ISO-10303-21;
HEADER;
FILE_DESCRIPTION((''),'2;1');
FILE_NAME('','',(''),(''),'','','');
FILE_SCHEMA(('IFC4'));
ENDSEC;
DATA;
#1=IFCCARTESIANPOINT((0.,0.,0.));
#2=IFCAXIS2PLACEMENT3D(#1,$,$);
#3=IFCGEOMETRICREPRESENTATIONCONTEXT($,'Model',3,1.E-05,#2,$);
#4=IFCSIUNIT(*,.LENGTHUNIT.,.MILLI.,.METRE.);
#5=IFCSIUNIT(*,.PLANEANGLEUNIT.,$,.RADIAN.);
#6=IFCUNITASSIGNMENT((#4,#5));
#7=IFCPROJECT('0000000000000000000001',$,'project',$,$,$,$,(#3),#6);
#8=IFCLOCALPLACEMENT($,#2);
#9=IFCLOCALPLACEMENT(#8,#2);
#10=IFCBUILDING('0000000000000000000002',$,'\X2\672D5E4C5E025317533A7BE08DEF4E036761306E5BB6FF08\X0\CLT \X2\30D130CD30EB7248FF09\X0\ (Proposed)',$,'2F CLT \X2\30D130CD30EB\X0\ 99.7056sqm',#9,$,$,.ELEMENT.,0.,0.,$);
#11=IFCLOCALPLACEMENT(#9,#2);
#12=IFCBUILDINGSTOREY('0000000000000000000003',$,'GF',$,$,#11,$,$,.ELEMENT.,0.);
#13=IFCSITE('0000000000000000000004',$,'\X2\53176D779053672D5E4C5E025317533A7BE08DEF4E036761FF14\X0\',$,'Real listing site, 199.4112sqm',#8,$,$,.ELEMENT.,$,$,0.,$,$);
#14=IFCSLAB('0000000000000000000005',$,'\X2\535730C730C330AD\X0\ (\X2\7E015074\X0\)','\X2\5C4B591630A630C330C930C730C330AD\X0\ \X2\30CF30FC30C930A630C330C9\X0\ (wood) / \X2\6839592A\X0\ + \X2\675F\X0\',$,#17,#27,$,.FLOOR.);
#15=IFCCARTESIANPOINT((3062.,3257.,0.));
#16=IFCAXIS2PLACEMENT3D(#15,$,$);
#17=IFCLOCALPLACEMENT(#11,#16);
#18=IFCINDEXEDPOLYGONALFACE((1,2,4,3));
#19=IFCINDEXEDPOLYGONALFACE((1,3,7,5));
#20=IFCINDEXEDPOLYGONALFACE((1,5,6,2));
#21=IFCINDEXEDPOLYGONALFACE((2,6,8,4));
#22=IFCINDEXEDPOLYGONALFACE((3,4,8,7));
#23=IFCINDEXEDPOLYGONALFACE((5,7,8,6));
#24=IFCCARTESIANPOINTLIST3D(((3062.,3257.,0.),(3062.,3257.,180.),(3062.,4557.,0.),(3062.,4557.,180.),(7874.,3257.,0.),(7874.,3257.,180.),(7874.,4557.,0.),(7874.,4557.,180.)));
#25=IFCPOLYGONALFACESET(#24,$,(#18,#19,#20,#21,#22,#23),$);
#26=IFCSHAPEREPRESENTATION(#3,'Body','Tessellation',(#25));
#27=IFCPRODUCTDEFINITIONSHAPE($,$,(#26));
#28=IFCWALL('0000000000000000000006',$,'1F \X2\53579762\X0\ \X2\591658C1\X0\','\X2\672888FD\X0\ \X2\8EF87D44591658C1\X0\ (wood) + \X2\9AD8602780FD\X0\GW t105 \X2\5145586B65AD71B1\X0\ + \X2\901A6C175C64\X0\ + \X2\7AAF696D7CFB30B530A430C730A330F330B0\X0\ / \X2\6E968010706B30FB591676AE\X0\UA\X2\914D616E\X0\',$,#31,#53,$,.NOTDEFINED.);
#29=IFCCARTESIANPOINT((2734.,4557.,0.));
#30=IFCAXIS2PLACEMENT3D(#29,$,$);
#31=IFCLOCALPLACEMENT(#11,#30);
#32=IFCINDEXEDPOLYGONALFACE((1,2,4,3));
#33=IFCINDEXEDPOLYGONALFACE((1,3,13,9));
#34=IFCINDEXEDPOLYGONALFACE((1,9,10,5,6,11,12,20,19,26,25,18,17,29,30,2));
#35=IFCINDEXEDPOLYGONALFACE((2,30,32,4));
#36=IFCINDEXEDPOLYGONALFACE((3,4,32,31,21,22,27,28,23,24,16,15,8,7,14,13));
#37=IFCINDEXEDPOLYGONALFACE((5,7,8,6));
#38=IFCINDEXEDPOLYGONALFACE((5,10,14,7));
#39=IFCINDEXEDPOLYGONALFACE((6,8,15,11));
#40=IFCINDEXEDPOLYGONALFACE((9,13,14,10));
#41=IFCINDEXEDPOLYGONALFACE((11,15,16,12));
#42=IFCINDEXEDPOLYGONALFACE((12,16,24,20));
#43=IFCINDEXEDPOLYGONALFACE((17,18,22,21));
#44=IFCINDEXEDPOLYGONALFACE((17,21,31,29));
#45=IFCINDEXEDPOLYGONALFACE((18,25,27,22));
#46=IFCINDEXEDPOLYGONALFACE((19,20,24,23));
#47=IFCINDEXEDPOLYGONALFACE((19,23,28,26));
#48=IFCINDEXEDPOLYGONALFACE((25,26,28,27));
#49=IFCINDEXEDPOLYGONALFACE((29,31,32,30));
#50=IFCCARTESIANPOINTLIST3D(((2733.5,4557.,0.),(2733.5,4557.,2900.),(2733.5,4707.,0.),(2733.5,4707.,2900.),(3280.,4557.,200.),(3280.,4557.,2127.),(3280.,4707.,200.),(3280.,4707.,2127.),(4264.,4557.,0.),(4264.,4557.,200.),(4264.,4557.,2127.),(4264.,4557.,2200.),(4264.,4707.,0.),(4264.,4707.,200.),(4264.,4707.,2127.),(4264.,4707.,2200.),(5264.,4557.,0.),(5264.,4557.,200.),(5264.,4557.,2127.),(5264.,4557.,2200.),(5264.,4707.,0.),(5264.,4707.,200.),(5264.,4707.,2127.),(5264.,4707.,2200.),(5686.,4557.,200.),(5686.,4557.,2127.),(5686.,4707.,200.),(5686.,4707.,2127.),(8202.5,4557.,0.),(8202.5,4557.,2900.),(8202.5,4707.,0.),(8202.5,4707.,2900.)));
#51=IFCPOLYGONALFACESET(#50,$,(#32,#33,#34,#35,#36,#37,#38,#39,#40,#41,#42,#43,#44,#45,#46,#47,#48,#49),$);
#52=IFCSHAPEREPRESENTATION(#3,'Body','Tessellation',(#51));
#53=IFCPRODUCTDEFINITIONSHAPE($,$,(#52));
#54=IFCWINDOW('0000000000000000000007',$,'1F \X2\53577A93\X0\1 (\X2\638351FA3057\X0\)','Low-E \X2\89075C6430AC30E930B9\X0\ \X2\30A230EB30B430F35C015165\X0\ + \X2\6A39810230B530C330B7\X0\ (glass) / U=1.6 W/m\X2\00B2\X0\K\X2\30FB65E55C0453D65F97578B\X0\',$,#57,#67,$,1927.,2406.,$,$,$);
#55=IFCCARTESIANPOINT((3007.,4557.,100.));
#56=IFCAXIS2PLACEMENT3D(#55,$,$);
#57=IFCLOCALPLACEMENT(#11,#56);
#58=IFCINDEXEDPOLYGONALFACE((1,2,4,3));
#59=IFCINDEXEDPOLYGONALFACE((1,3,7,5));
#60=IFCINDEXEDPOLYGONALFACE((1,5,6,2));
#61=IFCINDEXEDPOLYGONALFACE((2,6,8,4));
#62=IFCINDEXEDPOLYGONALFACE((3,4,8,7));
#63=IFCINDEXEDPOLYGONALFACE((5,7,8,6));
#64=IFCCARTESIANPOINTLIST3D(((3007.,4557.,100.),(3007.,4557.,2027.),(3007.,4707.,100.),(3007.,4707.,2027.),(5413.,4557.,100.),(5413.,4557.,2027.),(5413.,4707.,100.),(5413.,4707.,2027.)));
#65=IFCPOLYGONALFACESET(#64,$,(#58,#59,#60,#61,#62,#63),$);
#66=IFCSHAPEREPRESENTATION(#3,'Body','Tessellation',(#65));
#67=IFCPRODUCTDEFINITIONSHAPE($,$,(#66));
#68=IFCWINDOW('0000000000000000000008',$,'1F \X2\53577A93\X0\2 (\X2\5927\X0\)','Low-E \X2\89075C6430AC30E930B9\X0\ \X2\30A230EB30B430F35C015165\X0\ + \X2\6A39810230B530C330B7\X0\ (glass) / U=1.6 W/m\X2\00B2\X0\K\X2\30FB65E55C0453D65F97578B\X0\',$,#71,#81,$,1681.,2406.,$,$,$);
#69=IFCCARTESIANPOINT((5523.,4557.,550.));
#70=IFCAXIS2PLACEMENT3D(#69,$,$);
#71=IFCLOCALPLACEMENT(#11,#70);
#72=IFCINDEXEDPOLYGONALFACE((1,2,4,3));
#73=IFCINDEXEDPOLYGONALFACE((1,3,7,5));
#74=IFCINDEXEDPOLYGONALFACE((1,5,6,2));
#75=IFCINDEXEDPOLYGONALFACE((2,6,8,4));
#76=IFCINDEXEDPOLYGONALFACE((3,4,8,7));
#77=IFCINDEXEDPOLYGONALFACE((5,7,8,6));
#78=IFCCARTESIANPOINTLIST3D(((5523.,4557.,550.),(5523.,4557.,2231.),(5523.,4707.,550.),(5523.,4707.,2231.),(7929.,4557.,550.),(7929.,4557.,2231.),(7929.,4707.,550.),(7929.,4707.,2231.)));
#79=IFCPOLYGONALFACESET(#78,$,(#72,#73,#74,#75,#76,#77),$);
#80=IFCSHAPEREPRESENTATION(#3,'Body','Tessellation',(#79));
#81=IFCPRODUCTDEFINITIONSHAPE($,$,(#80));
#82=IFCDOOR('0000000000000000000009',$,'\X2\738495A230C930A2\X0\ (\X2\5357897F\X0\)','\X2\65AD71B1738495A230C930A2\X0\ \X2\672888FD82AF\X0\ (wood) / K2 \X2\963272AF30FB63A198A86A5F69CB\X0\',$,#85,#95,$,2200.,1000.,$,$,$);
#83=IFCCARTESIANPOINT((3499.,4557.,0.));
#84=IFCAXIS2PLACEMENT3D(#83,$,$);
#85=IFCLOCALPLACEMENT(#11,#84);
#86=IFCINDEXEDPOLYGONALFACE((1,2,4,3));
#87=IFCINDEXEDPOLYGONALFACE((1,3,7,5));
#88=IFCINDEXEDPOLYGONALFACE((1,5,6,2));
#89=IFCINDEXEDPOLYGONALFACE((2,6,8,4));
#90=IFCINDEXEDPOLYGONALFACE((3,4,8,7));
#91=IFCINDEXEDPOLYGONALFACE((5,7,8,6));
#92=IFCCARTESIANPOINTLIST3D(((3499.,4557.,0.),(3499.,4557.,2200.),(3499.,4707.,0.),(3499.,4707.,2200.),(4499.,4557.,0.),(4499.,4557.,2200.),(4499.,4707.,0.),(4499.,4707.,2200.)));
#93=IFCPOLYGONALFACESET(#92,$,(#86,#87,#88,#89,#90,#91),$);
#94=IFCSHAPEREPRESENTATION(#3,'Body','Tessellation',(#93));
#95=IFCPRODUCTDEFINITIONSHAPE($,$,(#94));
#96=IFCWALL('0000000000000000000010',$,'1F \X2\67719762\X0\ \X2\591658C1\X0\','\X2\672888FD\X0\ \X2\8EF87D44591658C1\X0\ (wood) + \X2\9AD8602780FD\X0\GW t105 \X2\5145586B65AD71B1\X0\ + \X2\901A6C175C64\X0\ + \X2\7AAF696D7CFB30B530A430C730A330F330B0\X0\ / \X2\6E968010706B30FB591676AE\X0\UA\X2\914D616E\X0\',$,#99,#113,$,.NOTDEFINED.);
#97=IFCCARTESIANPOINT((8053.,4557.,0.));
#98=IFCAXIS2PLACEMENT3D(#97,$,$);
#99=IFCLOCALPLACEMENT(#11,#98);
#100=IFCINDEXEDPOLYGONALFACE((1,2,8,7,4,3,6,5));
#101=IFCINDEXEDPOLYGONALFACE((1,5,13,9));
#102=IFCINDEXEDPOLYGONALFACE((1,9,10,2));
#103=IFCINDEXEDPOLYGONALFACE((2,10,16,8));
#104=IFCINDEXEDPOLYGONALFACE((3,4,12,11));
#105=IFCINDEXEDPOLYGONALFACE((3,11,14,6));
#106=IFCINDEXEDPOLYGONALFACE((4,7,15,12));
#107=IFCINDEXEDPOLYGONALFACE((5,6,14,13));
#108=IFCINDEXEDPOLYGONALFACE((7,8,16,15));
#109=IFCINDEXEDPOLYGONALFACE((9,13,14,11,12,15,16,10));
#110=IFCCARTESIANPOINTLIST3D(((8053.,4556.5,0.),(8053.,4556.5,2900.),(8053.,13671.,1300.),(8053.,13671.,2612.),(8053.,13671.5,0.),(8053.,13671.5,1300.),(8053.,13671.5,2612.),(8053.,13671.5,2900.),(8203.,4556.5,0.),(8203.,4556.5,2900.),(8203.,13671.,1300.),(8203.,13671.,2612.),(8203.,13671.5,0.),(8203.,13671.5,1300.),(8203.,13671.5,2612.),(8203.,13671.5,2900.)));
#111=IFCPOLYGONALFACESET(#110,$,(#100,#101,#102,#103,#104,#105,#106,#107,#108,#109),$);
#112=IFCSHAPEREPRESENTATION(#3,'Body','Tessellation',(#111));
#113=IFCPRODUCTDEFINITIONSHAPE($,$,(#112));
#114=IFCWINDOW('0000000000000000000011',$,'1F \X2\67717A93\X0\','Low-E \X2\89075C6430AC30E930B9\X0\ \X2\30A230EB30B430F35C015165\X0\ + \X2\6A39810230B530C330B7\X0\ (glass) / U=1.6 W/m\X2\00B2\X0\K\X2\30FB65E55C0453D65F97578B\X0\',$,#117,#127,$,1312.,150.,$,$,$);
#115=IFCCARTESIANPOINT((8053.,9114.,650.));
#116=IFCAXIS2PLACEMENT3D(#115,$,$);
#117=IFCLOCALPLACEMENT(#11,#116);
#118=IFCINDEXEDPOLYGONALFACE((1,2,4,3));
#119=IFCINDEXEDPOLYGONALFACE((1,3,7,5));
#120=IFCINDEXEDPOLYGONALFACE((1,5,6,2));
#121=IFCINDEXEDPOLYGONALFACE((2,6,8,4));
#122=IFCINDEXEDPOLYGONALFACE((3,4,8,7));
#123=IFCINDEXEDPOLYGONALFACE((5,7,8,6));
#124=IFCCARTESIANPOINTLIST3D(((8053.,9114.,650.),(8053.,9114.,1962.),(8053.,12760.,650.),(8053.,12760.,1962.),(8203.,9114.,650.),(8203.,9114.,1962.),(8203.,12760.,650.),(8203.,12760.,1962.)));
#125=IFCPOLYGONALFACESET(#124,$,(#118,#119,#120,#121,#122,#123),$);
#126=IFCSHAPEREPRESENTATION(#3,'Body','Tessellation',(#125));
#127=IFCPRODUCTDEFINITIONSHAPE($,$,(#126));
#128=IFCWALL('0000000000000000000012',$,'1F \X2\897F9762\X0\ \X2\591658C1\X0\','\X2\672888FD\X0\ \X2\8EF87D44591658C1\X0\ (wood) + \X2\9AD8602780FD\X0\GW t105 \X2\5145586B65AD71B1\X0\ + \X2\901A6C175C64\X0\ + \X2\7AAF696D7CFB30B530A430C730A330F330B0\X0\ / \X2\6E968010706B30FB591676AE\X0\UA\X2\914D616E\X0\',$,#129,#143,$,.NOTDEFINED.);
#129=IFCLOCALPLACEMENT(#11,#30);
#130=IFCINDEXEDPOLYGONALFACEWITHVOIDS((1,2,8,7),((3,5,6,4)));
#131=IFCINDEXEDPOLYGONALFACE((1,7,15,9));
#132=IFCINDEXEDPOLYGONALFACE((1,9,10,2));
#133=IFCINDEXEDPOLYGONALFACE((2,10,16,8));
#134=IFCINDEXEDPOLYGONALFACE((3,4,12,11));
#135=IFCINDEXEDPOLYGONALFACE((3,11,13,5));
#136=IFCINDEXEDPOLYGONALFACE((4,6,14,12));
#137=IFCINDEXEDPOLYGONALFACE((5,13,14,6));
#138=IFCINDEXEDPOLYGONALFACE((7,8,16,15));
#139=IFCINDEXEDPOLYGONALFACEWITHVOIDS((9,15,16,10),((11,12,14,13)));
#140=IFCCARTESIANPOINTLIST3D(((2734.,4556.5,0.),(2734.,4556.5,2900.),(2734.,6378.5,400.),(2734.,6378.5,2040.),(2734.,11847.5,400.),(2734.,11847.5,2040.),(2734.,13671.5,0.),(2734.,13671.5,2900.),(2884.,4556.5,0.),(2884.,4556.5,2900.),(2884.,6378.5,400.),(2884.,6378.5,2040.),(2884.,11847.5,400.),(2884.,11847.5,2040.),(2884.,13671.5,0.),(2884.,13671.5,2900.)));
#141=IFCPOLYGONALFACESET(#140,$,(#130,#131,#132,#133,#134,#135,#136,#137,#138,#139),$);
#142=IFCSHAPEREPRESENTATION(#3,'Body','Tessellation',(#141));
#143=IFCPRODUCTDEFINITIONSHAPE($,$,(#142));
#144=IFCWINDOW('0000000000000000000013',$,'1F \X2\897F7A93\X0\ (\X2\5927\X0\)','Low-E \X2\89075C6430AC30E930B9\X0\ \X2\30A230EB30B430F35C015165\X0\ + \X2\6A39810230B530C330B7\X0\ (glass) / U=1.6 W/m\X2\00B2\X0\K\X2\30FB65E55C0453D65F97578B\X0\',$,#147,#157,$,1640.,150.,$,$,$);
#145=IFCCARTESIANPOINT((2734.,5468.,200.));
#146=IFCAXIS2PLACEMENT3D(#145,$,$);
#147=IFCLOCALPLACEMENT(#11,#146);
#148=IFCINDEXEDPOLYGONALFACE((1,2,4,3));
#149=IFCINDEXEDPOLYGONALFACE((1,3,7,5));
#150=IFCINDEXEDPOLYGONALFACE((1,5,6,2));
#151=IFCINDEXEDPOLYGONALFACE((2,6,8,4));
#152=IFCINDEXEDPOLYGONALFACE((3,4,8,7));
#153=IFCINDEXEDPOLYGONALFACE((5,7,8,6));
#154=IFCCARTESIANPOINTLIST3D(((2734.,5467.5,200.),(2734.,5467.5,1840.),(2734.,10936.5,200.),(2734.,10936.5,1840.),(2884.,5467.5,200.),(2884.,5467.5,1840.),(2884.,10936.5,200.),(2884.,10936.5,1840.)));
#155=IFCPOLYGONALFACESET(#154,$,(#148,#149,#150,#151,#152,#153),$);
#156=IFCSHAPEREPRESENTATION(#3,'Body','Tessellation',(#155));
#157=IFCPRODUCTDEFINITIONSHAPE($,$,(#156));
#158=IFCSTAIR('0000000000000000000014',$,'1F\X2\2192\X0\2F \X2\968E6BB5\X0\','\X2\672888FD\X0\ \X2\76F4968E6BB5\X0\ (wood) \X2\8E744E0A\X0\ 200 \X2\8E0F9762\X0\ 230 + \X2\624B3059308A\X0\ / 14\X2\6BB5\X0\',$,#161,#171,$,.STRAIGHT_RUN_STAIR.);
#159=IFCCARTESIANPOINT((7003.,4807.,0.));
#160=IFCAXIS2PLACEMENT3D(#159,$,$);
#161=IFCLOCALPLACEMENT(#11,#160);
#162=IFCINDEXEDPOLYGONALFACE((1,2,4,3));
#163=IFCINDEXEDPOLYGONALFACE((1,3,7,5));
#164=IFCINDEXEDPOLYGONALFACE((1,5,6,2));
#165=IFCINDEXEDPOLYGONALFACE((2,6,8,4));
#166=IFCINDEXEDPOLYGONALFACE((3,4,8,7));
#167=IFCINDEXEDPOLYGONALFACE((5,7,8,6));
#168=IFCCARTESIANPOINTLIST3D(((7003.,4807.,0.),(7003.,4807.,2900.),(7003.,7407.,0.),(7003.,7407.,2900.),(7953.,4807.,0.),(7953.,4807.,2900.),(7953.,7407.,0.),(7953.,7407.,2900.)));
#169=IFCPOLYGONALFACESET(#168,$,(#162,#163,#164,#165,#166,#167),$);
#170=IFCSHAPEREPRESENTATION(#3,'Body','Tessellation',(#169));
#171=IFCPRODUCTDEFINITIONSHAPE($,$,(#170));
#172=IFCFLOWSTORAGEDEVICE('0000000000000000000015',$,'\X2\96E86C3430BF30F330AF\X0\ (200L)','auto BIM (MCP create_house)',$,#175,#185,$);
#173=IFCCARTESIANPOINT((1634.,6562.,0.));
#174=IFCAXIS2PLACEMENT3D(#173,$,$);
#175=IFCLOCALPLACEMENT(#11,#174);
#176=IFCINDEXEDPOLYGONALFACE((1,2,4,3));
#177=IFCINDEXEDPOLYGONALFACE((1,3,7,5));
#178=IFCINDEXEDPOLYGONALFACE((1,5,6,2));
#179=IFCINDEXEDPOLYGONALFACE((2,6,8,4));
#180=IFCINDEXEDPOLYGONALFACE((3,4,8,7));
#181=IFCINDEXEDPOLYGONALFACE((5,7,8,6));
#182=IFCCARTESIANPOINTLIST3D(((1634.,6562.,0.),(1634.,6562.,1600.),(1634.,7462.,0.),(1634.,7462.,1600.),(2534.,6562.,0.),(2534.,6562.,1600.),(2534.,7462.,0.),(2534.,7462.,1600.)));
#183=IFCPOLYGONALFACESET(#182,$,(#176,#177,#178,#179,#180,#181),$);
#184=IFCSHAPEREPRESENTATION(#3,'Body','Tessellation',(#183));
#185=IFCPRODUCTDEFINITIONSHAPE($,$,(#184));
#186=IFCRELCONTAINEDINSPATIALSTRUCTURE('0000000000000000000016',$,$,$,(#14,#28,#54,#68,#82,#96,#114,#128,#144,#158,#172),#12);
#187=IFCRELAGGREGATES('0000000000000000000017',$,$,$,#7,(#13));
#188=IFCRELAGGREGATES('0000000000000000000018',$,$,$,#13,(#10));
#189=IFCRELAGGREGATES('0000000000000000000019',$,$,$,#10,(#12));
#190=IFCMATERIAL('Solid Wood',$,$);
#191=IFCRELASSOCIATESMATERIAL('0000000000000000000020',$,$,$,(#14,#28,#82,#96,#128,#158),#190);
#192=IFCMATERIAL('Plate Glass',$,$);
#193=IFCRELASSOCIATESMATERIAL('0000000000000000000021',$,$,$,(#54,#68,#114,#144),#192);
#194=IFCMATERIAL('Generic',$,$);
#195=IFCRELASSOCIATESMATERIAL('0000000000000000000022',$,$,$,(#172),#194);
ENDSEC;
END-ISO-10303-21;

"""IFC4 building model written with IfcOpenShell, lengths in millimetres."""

from ifc_helpers import new_model, si_unit, frame, frame_2d, origin, place, context, project, spatial, rectangle, extrude, material, element, fill, save


model = new_model("IFC4")

# Units and contexts
model_context = context("Model", 3, precision=1e-05, world=origin())
ifc_project = project(units=[si_unit("LENGTHUNIT", "METRE", prefix="MILLI"), si_unit("PLANEANGLEUNIT", "RADIAN")], contexts=[model_context])

# Site, building, storey
site_placement = place(None, origin())
site = spatial("IfcSite", under=ifc_project, at=site_placement, Name="北海道札幌市北区篠路七条４", ObjectType="Real listing site, 199.4112sqm", CompositionType="ELEMENT", RefElevation=0.0)
building_placement = place(site_placement, origin())
building = spatial("IfcBuilding", under=site, at=building_placement, Name="札幌市北区篠路七条の家（CLT パネル版） (Proposed)", ObjectType="2F CLT パネル 99.7056sqm", CompositionType="ELEMENT", ElevationOfRefHeight=0.0, ElevationOfTerrain=0.0)
storey_placement = place(building_placement, origin())
storey = spatial("IfcBuildingStorey", under=building, at=storey_placement, Name="GF", CompositionType="ELEMENT", Elevation=0.0)

# Slab
ifc_material_1 = material(Name="Solid Wood")
slab_1_placement = place(storey_placement, frame((3062.0, 3257.0, 0.0)))
element("IfcSlab", 1, at=slab_1_placement, inside=storey, material=ifc_material_1, Name="南デッキ (縁側)", Description="屋外ウッドデッキ ハードウッド (wood) / 根太 + 束", PredefinedType="FLOOR", context=model_context, shape_type="SweptSolid", body=[
    extrude(rectangle(XDim=4812.0, YDim=1300.0, at=frame_2d((2406.0, 650.0))), frame((3062.0, 3257.0, 0.0)), (0.0, 0.0, 1.0), 180.0),
])

# Wall, openings, windows, door
wall_1_placement = place(storey_placement, frame((2734.0, 4557.0, 0.0)))
wall_1 = element("IfcWall", 2, at=wall_1_placement, inside=storey, material=ifc_material_1, Name="1F 南面 外壁", Description="木製 軸組外壁 (wood) + 高性能GW t105 充填断熱 + 通気層 + 窯業系サイディング / 準耐火・外皮UA配慮", PredefinedType="NOTDEFINED", context=model_context, shape_type="SweptSolid", body=[
    extrude(rectangle(XDim=5469.0, YDim=150.0, at=frame_2d((2734.0, 75.0))), frame((2734.0, 4557.0, 0.0)), (0.0, 0.0, 1.0), 2900.0),
])
opening_1_placement = place(storey_placement, frame((3007.0, 4557.0, 100.0)))
opening_1 = element("IfcOpeningElement", 3, at=opening_1_placement, cuts=wall_1, PredefinedType="NOTDEFINED", context=model_context, shape_type="SweptSolid", body=[
    extrude(rectangle(XDim=2406.0, YDim=150.0, at=frame_2d((1203.0, 75.0))), frame((3007.0, 4557.0, 100.0)), (0.0, 0.0, 1.0), 1927.0),
])
opening_2_placement = place(storey_placement, frame((5523.0, 4557.0, 550.0)))
opening_2 = element("IfcOpeningElement", 4, at=opening_2_placement, cuts=wall_1, PredefinedType="NOTDEFINED", context=model_context, shape_type="SweptSolid", body=[
    extrude(rectangle(XDim=2406.0, YDim=150.0, at=frame_2d((1203.0, 75.0))), frame((5523.0, 4557.0, 550.0)), (0.0, 0.0, 1.0), 1681.0),
])
opening_3_placement = place(storey_placement, frame((3499.0, 4557.0, 0.0)))
opening_3 = element("IfcOpeningElement", 5, at=opening_3_placement, cuts=wall_1, PredefinedType="NOTDEFINED", context=model_context, shape_type="SweptSolid", body=[
    extrude(rectangle(XDim=1000.0, YDim=150.0, at=frame_2d((500.0, 75.0))), frame((3499.0, 4557.0, 0.0)), (0.0, 0.0, 1.0), 2200.0),
])
ifc_material_2 = material(Name="Plate Glass")
window_1_placement = place(storey_placement, frame((3007.0, 4557.0, 100.0)))
window_1 = element("IfcWindow", 6, at=window_1_placement, inside=storey, material=ifc_material_2, Name="1F 南窓1 (掃出し)", Description="Low-E 複層ガラス アルゴン封入 + 樹脂サッシ (glass) / U=1.6 W/m²K・日射取得型", OverallHeight=1927.0, OverallWidth=2406.0, context=model_context, shape_type="SweptSolid", body=[
    extrude(rectangle(XDim=2406.0, YDim=150.0, at=frame_2d((1203.0, 75.0))), frame((3007.0, 4557.0, 100.0)), (0.0, 0.0, 1.0), 1927.0),
])
fill(opening_1, window_1)
window_2_placement = place(storey_placement, frame((5523.0, 4557.0, 550.0)))
window_2 = element("IfcWindow", 7, at=window_2_placement, inside=storey, material=ifc_material_2, Name="1F 南窓2 (大)", Description="Low-E 複層ガラス アルゴン封入 + 樹脂サッシ (glass) / U=1.6 W/m²K・日射取得型", OverallHeight=1681.0, OverallWidth=2406.0, context=model_context, shape_type="SweptSolid", body=[
    extrude(rectangle(XDim=2406.0, YDim=150.0, at=frame_2d((1203.0, 75.0))), frame((5523.0, 4557.0, 550.0)), (0.0, 0.0, 1.0), 1681.0),
])
fill(opening_2, window_2)
door_placement = place(storey_placement, frame((3499.0, 4557.0, 0.0)))
door = element("IfcDoor", 8, at=door_placement, inside=storey, material=ifc_material_1, Name="玄関ドア (南西)", Description="断熱玄関ドア 木製芯 (wood) / K2 防犯・採風機構", OverallHeight=2200.0, OverallWidth=1000.0, context=model_context, shape_type="SweptSolid", body=[
    extrude(rectangle(XDim=1000.0, YDim=150.0, at=frame_2d((500.0, 75.0))), frame((3499.0, 4557.0, 0.0)), (0.0, 0.0, 1.0), 2200.0),
])
fill(opening_3, door)

# Walls, openings, windows
wall_2_placement = place(storey_placement, frame((8053.0, 4557.0, 0.0)))
wall_2 = element("IfcWall", 9, at=wall_2_placement, inside=storey, material=ifc_material_1, Name="1F 東面 外壁", Description="木製 軸組外壁 (wood) + 高性能GW t105 充填断熱 + 通気層 + 窯業系サイディング / 準耐火・外皮UA配慮", PredefinedType="NOTDEFINED", context=model_context, shape_type="SweptSolid", body=[
    extrude(rectangle(XDim=150.0, YDim=9115.0, at=frame_2d((75.0, 4557.0))), frame((8053.0, 4557.0, 0.0)), (0.0, 0.0, 1.0), 2900.0),
])
opening_4_placement = place(storey_placement, frame((8053.0, 9114.0, 650.0)))
opening_4 = element("IfcOpeningElement", 10, at=opening_4_placement, cuts=wall_2, PredefinedType="NOTDEFINED", context=model_context, shape_type="SweptSolid", body=[
    extrude(rectangle(XDim=150.0, YDim=3646.0, at=frame_2d((75.0, 1823.0))), frame((8053.0, 9114.0, 650.0)), (0.0, 0.0, 1.0), 1312.0),
])
window_3_placement = place(storey_placement, frame((8053.0, 9114.0, 650.0)))
window_3 = element("IfcWindow", 11, at=window_3_placement, inside=storey, material=ifc_material_2, Name="1F 東窓", Description="Low-E 複層ガラス アルゴン封入 + 樹脂サッシ (glass) / U=1.6 W/m²K・日射取得型", OverallHeight=1312.0, OverallWidth=150.0, context=model_context, shape_type="SweptSolid", body=[
    extrude(rectangle(XDim=150.0, YDim=3646.0, at=frame_2d((75.0, 1823.0))), frame((8053.0, 9114.0, 650.0)), (0.0, 0.0, 1.0), 1312.0),
])
fill(opening_4, window_3)
wall_3_placement = place(storey_placement, frame((2734.0, 4557.0, 0.0)))
wall_3 = element("IfcWall", 12, at=wall_3_placement, inside=storey, material=ifc_material_1, Name="1F 西面 外壁", Description="木製 軸組外壁 (wood) + 高性能GW t105 充填断熱 + 通気層 + 窯業系サイディング / 準耐火・外皮UA配慮", PredefinedType="NOTDEFINED", context=model_context, shape_type="SweptSolid", body=[
    extrude(rectangle(XDim=150.0, YDim=9115.0, at=frame_2d((75.0, 4557.0))), frame((2734.0, 4557.0, 0.0)), (0.0, 0.0, 1.0), 2900.0),
])
opening_5_placement = place(storey_placement, frame((2734.0, 5468.0, 200.0)))
opening_5 = element("IfcOpeningElement", 13, at=opening_5_placement, cuts=wall_3, PredefinedType="NOTDEFINED", context=model_context, shape_type="SweptSolid", body=[
    extrude(rectangle(XDim=150.0, YDim=5469.0, at=frame_2d((75.0, 2734.0))), frame((2734.0, 5468.0, 200.0)), (0.0, 0.0, 1.0), 1640.0),
])
window_4_placement = place(storey_placement, frame((2734.0, 5468.0, 200.0)))
window_4 = element("IfcWindow", 14, at=window_4_placement, inside=storey, material=ifc_material_2, Name="1F 西窓 (大)", Description="Low-E 複層ガラス アルゴン封入 + 樹脂サッシ (glass) / U=1.6 W/m²K・日射取得型", OverallHeight=1640.0, OverallWidth=150.0, context=model_context, shape_type="SweptSolid", body=[
    extrude(rectangle(XDim=150.0, YDim=5469.0, at=frame_2d((75.0, 2734.0))), frame((2734.0, 5468.0, 200.0)), (0.0, 0.0, 1.0), 1640.0),
])
fill(opening_5, window_4)

# Stair
stair_placement = place(storey_placement, frame((7003.0, 4807.0, 0.0)))
element("IfcStair", 15, at=stair_placement, inside=storey, material=ifc_material_1, Name="1F→2F 階段", Description="木製 直階段 (wood) 蹴上 200 踏面 230 + 手すり / 14段", PredefinedType="STRAIGHT_RUN_STAIR", context=model_context, shape_type="SweptSolid", body=[
    extrude(rectangle(XDim=950.0, YDim=2600.0, at=frame_2d((475.0, 1300.0))), frame((7003.0, 4807.0, 0.0)), (0.0, 0.0, 1.0), 2900.0),
])

# Shared definitions
ifc_material_3 = material(Name="Generic")

# Flow storage device
flow_storage_device_placement = place(storey_placement, frame((1634.0, 6562.0, 0.0)))
element("IfcFlowStorageDevice", 16, at=flow_storage_device_placement, inside=storey, material=ifc_material_3, Name="雨水タンク (200L)", Description="auto BIM (MCP create_house)", context=model_context, shape_type="SweptSolid", body=[
    extrude(rectangle(XDim=900.0, YDim=900.0, at=frame_2d((450.0, 450.0))), frame((1634.0, 6562.0, 0.0)), (0.0, 0.0, 1.0), 1600.0),
])

save(model, "model.ifc")
